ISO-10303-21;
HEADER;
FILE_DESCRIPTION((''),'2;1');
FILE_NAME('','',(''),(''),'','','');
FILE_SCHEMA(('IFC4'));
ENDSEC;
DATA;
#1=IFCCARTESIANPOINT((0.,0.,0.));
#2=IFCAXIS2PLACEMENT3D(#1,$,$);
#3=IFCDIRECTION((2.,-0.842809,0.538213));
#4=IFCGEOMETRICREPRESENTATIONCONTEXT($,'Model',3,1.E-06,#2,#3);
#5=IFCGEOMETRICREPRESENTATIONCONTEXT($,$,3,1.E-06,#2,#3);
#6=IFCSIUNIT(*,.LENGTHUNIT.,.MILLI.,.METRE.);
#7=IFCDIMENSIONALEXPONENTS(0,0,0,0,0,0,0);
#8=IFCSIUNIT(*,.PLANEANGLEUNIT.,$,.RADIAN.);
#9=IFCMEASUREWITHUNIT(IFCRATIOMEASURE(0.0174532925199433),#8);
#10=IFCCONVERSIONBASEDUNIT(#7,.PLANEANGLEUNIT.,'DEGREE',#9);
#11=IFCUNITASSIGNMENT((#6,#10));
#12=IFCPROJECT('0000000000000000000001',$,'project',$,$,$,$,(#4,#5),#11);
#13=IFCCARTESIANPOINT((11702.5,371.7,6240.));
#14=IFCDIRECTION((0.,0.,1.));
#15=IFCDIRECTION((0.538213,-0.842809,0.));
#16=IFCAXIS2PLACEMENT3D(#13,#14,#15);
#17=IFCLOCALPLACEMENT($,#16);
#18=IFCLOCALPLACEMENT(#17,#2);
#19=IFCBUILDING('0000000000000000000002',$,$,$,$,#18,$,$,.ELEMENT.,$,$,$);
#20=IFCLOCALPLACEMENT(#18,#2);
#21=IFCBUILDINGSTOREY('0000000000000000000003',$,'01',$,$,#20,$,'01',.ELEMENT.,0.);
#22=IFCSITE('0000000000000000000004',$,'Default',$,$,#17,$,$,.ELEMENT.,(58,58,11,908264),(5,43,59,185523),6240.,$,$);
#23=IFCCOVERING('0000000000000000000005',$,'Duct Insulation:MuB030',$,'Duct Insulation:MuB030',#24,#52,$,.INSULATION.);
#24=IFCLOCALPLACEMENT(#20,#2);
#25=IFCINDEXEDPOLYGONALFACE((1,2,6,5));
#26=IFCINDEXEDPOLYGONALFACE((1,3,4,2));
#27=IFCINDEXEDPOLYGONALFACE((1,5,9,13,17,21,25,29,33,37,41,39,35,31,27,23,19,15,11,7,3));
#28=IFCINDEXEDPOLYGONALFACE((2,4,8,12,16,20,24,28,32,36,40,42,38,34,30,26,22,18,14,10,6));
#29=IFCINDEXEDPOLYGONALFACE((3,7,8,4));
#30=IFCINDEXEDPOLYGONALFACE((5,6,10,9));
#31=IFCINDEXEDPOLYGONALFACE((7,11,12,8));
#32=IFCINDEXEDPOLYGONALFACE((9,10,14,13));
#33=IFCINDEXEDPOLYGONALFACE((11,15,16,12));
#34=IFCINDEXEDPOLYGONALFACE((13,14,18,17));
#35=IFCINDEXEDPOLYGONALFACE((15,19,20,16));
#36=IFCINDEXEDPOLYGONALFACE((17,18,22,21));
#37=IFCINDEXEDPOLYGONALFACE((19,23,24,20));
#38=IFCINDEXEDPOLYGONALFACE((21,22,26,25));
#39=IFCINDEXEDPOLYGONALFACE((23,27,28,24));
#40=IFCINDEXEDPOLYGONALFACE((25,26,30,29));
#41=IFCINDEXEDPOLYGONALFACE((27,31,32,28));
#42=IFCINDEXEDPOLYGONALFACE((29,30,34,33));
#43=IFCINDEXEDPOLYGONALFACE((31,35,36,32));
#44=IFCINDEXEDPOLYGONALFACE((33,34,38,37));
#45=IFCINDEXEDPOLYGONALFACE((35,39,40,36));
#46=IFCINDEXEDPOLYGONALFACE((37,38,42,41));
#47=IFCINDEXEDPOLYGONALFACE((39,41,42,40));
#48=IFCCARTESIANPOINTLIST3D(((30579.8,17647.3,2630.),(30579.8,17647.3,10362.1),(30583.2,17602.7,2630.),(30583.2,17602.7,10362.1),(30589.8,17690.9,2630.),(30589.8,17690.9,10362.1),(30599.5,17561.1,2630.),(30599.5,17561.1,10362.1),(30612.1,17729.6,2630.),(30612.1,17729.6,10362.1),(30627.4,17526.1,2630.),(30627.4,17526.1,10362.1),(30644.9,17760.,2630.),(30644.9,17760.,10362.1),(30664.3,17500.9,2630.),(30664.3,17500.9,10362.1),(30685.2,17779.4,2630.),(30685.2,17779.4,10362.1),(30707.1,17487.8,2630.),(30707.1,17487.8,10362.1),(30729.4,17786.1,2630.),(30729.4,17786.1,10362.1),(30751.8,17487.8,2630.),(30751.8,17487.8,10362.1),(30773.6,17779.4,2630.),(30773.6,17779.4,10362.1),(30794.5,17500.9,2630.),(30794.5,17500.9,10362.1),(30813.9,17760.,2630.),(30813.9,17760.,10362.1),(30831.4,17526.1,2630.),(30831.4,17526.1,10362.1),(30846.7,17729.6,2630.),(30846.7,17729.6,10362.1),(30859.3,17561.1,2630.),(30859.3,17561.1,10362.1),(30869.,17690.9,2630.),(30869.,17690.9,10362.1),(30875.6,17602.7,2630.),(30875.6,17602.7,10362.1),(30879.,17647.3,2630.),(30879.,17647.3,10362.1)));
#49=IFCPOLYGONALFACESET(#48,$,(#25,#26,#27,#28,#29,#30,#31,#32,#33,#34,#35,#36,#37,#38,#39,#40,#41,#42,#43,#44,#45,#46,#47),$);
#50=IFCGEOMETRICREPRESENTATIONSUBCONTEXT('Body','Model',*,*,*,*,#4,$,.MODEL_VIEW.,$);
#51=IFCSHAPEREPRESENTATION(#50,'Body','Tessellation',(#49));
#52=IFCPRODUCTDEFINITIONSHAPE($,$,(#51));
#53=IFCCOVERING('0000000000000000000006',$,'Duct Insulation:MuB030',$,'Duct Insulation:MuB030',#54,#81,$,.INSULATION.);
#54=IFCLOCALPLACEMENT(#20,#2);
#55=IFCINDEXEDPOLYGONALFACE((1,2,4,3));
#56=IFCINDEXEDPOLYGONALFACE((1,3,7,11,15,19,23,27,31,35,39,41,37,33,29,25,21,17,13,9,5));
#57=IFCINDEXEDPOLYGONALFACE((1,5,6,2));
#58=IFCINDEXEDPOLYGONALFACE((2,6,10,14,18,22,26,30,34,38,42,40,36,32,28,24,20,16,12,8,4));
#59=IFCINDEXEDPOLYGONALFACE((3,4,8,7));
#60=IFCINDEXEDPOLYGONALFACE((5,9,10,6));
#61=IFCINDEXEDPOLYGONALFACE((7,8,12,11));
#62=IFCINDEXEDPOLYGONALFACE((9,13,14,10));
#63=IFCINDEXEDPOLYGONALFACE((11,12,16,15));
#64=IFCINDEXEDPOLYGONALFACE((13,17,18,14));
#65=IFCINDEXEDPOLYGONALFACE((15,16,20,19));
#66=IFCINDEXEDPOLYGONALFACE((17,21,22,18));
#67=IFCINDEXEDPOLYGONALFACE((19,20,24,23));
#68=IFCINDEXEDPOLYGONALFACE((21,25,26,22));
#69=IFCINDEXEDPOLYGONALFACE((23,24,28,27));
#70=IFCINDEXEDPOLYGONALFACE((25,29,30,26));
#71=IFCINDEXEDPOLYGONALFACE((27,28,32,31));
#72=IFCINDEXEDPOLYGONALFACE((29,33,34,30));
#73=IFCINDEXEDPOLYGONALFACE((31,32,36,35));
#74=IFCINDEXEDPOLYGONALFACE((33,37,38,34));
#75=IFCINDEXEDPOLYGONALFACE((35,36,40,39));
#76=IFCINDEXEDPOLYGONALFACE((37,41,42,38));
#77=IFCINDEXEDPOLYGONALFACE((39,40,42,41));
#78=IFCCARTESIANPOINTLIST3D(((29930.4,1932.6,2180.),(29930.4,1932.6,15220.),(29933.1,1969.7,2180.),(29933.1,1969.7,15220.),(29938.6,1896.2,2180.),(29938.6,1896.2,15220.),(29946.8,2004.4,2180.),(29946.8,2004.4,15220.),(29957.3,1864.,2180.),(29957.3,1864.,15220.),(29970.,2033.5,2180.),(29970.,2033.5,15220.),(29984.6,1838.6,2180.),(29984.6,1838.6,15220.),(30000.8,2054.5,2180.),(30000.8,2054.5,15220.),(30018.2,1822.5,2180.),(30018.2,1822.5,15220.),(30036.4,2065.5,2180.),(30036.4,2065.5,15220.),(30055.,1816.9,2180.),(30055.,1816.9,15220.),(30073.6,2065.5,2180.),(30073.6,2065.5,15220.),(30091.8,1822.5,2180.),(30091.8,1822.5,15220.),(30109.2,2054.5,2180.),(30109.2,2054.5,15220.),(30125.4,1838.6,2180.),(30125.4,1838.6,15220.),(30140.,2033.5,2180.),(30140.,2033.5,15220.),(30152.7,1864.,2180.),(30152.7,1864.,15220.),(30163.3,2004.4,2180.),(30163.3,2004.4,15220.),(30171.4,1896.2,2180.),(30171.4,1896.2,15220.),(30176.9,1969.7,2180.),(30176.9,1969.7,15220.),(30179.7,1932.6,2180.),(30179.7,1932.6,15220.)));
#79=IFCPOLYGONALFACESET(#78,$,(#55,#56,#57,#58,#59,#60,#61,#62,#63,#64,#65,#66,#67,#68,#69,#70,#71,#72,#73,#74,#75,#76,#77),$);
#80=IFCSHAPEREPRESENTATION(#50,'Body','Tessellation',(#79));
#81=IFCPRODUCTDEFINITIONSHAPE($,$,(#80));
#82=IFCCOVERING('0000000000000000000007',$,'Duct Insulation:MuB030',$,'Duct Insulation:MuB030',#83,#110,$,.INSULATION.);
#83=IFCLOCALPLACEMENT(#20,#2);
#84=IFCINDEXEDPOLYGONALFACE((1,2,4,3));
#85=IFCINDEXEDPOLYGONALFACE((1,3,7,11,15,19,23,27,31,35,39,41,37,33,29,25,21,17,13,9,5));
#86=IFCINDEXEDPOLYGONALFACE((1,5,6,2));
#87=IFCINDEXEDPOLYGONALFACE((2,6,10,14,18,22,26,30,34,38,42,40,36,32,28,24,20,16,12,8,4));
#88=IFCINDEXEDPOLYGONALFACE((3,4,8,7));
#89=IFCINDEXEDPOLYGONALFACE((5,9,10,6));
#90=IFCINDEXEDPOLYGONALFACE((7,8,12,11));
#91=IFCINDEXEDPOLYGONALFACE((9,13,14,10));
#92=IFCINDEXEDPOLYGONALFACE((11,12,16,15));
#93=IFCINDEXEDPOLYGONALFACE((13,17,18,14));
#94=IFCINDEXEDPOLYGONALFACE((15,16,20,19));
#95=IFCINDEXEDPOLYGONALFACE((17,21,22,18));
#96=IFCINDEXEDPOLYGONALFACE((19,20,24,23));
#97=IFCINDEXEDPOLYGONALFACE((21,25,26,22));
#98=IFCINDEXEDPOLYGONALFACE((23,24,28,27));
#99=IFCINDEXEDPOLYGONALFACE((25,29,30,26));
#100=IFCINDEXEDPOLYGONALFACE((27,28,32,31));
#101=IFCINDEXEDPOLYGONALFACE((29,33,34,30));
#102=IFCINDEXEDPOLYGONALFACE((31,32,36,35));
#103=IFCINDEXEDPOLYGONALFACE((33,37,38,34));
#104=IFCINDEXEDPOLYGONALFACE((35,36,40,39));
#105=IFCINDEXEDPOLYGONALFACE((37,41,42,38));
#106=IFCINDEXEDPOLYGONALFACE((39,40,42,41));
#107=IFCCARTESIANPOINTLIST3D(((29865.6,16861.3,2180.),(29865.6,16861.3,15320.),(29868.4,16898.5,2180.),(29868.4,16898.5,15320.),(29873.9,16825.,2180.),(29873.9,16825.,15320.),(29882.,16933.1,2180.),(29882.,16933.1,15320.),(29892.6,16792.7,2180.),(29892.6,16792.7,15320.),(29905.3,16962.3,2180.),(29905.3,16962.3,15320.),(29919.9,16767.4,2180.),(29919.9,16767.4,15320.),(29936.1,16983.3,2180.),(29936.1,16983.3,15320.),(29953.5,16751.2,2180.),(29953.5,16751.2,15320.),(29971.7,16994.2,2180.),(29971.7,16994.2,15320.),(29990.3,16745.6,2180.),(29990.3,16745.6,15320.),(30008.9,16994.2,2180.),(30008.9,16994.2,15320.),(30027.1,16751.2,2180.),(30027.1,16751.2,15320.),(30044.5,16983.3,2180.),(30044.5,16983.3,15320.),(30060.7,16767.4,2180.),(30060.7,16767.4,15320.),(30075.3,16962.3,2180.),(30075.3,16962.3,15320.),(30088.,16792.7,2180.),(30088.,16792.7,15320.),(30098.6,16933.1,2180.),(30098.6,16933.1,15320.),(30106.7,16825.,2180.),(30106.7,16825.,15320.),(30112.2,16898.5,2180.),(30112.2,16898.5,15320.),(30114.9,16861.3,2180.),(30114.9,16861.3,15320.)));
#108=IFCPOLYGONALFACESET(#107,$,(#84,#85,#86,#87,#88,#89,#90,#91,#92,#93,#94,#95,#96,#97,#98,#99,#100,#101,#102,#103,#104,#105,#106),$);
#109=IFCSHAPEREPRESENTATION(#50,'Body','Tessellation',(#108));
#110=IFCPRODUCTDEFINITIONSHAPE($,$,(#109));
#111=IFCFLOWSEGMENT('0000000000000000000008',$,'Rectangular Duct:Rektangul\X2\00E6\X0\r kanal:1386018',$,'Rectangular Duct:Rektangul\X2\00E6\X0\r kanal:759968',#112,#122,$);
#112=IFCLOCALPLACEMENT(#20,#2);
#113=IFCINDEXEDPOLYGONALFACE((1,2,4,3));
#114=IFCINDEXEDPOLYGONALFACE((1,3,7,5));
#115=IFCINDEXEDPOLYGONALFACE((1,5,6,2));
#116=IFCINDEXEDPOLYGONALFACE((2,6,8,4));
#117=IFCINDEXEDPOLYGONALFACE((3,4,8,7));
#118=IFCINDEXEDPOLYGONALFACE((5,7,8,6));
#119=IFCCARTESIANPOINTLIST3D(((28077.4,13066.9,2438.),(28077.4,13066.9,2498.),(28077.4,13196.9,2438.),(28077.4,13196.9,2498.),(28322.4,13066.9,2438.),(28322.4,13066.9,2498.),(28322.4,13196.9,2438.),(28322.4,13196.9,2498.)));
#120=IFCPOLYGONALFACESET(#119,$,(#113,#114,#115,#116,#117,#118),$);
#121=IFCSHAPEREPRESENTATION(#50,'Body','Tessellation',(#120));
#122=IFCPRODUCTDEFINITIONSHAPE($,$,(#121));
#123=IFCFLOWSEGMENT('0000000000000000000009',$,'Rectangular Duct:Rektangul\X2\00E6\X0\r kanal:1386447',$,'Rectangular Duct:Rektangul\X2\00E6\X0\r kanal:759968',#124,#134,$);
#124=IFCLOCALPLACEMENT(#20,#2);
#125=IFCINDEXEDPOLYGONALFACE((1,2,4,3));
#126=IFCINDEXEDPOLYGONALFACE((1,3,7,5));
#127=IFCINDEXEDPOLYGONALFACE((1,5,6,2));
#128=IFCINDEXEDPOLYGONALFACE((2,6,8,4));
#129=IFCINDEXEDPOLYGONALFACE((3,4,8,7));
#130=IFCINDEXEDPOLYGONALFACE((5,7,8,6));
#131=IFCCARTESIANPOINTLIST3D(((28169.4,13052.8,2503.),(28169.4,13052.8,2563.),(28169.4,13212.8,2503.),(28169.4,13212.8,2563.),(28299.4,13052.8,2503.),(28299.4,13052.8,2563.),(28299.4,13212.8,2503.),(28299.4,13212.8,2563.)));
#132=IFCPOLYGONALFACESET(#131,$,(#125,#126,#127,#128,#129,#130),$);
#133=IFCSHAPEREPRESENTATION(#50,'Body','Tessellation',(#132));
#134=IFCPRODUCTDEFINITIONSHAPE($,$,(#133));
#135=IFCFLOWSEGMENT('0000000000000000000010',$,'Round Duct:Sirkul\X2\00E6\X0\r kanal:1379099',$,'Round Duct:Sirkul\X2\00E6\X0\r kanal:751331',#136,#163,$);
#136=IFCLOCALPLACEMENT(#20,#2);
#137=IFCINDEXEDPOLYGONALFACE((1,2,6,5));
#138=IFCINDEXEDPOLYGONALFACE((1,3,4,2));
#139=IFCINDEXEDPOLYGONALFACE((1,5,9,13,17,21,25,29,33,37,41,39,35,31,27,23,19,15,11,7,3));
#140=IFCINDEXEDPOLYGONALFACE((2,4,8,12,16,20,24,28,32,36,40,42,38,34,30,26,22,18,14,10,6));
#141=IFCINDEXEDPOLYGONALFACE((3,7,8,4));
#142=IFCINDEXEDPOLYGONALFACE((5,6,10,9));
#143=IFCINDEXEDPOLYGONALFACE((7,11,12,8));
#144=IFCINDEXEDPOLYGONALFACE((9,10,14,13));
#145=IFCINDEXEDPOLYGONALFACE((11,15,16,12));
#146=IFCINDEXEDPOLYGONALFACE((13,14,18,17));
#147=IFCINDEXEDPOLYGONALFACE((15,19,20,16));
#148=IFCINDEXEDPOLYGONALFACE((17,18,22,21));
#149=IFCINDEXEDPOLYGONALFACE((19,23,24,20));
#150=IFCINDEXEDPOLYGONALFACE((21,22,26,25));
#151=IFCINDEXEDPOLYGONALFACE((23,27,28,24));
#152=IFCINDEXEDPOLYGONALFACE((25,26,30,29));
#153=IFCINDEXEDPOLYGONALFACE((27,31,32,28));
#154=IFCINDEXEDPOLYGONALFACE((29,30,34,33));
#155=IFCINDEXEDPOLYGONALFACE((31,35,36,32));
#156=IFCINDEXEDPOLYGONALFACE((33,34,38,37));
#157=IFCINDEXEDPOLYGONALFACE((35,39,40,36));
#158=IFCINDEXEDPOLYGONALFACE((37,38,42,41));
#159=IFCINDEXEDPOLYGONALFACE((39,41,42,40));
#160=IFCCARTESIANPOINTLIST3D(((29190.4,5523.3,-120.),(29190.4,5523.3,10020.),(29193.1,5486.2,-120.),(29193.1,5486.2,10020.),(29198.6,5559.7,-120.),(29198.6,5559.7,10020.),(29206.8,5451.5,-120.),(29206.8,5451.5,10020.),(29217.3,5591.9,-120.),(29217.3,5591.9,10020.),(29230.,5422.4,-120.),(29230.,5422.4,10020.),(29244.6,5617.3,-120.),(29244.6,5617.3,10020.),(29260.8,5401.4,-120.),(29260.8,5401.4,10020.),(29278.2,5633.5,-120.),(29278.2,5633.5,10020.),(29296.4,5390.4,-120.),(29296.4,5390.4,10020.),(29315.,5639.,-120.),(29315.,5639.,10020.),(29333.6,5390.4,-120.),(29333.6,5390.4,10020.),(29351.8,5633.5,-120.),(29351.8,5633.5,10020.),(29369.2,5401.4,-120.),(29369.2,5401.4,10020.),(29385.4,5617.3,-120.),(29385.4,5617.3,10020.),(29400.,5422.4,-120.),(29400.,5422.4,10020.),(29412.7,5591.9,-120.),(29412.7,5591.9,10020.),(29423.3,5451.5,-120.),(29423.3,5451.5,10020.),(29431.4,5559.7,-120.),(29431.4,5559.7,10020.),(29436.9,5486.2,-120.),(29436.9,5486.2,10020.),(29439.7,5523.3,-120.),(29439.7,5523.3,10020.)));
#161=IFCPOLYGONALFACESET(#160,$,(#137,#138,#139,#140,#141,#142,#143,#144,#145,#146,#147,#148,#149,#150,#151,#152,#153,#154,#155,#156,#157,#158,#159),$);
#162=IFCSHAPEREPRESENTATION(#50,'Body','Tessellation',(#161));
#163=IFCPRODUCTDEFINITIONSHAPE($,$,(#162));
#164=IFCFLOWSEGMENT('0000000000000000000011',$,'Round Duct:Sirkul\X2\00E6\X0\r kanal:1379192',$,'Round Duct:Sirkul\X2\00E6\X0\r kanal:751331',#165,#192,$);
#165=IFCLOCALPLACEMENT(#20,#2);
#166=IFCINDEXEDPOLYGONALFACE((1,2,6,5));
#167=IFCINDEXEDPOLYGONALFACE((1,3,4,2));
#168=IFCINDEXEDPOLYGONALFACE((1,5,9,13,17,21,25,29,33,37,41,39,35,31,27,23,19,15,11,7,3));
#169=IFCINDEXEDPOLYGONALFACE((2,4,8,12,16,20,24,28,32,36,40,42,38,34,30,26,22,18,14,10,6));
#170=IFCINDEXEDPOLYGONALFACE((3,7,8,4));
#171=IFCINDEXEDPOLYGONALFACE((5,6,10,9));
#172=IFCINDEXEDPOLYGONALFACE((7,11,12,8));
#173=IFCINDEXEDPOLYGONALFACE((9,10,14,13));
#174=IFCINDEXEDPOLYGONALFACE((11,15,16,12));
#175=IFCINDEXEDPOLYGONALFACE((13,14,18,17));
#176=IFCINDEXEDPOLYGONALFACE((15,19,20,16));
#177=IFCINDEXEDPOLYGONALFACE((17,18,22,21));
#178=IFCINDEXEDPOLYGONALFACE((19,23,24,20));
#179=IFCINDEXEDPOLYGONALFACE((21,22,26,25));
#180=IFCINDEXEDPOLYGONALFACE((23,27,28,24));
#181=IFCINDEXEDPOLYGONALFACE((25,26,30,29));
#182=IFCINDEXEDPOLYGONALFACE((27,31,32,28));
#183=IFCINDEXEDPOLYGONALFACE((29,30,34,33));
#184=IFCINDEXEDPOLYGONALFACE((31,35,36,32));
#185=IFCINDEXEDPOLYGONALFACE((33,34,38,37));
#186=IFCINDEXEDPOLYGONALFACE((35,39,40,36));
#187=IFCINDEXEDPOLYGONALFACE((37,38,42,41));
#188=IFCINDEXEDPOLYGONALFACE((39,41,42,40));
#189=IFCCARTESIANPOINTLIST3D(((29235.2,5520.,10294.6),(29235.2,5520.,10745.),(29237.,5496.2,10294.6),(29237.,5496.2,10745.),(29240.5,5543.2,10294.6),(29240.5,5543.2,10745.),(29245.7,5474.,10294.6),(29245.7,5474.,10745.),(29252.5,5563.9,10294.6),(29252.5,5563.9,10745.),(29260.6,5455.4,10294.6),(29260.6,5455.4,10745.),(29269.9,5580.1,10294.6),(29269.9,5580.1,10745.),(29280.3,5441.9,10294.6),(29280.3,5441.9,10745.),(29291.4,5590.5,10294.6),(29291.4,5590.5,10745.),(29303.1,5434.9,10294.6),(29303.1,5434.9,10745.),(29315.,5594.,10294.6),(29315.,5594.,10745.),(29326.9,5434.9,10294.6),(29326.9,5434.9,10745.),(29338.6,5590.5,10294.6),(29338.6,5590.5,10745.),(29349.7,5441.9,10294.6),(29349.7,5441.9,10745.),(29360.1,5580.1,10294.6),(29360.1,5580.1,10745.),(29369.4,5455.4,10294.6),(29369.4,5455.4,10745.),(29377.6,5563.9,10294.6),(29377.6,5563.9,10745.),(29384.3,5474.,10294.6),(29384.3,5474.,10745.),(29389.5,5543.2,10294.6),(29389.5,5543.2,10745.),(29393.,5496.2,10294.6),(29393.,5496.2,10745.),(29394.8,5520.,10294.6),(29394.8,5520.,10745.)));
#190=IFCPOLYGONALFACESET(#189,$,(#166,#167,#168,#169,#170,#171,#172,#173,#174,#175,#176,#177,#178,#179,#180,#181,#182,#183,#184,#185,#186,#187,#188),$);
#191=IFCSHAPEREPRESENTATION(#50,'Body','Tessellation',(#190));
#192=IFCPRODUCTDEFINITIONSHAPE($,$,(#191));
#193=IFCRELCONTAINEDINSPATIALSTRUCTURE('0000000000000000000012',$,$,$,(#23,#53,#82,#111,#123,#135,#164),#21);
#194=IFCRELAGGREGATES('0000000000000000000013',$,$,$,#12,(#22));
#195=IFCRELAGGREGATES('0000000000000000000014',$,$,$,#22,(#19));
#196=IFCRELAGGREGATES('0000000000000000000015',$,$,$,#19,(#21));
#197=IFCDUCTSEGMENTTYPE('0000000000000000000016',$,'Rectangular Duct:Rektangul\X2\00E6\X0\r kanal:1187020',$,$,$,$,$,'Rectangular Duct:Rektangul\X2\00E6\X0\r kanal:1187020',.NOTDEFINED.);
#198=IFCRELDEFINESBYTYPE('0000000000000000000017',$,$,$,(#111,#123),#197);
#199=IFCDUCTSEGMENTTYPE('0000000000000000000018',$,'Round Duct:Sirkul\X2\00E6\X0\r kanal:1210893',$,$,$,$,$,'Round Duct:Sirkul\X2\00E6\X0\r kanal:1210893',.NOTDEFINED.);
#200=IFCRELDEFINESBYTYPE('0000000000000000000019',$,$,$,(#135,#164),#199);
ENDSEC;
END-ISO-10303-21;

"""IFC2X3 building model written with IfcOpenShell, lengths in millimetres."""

from ifc_helpers import new_model, entity, si_unit, converted_unit, direction, frame, frame_2d, origin, origin_2d_with_axis, place, context, subcontext, project, spatial, rectangle, circle, extrude, type_object, element, save


model = new_model("IFC2X3")

# Units and contexts
model_context = context("Model", 3, precision=1e-06, world=origin(), true_north=direction((2.0, -0.842809, 0.538213)))
context_of_model = context(None, 3, precision=1e-06, world=origin(), true_north=direction((2.0, -0.842809, 0.538213)))
body_context = subcontext(model_context, "Body", "Model", "MODEL_VIEW")
ifc_project = project(units=[si_unit("LENGTHUNIT", "METRE", prefix="MILLI"), converted_unit("PLANEANGLEUNIT", "DEGREE", entity("IfcRatioMeasure", 0.0174532925199433), si_unit("PLANEANGLEUNIT", "RADIAN"), dimensions=[0, 0, 0, 0, 0, 0, 0])], contexts=[model_context, context_of_model])

# Site, building, storey
site_placement = place(None, frame((11702.5, 371.7, 6240.0), z_axis=(0.0, 0.0, 1.0), x_axis=(0.538213, -0.842809, 0.0)))
site = spatial("IfcSite", under=ifc_project, at=site_placement, Name="Default", CompositionType="ELEMENT", RefLatitude=(58, 58, 11, 908264), RefLongitude=(5, 43, 59, 185523), RefElevation=6240.0)
building_placement = place(site_placement, origin())
building = spatial("IfcBuilding", under=site, at=building_placement, CompositionType="ELEMENT")
storey_placement = place(building_placement, origin())
storey = spatial("IfcBuildingStorey", under=building, at=storey_placement, Name="01", LongName="01", CompositionType="ELEMENT", Elevation=0.0)

# Coverings
covering_1_placement = place(storey_placement, origin())
element("IfcCovering", 1, at=covering_1_placement, inside=storey, Name="Duct Insulation:MuB030", ObjectType="Duct Insulation:MuB030", PredefinedType="INSULATION", context=body_context, shape_type="SweptSolid", body=[
    extrude(circle(Radius=150.0, at=frame_2d((0.0, 0.0), x_axis=(1.0, 0.0))), frame((30729.4, 17636.1, 2630.0), z_axis=(0.0, 0.0, 1.0), x_axis=(0.0, 1.0, 0.0)), (0.0, 0.0, 1.0), 7732.1),
])
covering_2_placement = place(storey_placement, origin())
element("IfcCovering", 2, at=covering_2_placement, inside=storey, Name="Duct Insulation:MuB030", ObjectType="Duct Insulation:MuB030", PredefinedType="INSULATION", context=body_context, shape_type="SweptSolid", body=[
    extrude(circle(Radius=125.0, at=frame_2d((0.0, 0.0), x_axis=(1.0, 0.0))), frame((30055.0, 1941.9, 2180.0), z_axis=(0.0, 0.0, 1.0), x_axis=(0.0, -1.0, 0.0)), (0.0, 0.0, 1.0), 13040.0),
])
covering_3_placement = place(storey_placement, origin())
element("IfcCovering", 3, at=covering_3_placement, inside=storey, Name="Duct Insulation:MuB030", ObjectType="Duct Insulation:MuB030", PredefinedType="INSULATION", context=body_context, shape_type="SweptSolid", body=[
    extrude(circle(Radius=125.0, at=origin_2d_with_axis()), frame((29990.3, 16870.6, 2180.0), z_axis=(0.0, 0.0, 1.0), x_axis=(0.0, -1.0, 0.0)), (0.0, 0.0, 1.0), 13140.0),
])

# Flow segments
duct_segment_type_1 = type_object("IfcDuctSegmentType", Name="Rectangular Duct:Rektangulær kanal:1187020", ElementType="Rectangular Duct:Rektangulær kanal:1187020", PredefinedType="NOTDEFINED")
flow_segment_1_placement = place(storey_placement, origin())
element("IfcFlowSegment", 4, at=flow_segment_1_placement, inside=storey, type_object=duct_segment_type_1, Name="Rectangular Duct:Rektangulær kanal:1386018", ObjectType="Rectangular Duct:Rektangulær kanal:759968", context=body_context, shape_type="SweptSolid", body=[
    extrude(rectangle(XDim=245.0, YDim=130.0, at=frame_2d((0.0, 0.0), x_axis=(1.0, 0.0))), frame((28199.9, 13131.9, 2438.0), z_axis=(0.0, 0.0, 1.0), x_axis=(-1.0, 0.0, 0.0)), (0.0, 0.0, 1.0), 60.0),
])
flow_segment_2_placement = place(storey_placement, origin())
element("IfcFlowSegment", 5, at=flow_segment_2_placement, inside=storey, type_object=duct_segment_type_1, Name="Rectangular Duct:Rektangulær kanal:1386447", ObjectType="Rectangular Duct:Rektangulær kanal:759968", context=body_context, shape_type="SweptSolid", body=[
    extrude(rectangle(XDim=160.0, YDim=130.0, at=frame_2d((0.0, 0.0), x_axis=(1.0, 0.0))), frame((28234.4, 13132.8, 2503.0), z_axis=(0.0, 0.0, 1.0), x_axis=(0.0, 1.0, 0.0)), (0.0, 0.0, 1.0), 60.0),
])
duct_segment_type_2 = type_object("IfcDuctSegmentType", Name="Round Duct:Sirkulær kanal:1210893", ElementType="Round Duct:Sirkulær kanal:1210893", PredefinedType="NOTDEFINED")
flow_segment_3_placement = place(storey_placement, origin())
element("IfcFlowSegment", 6, at=flow_segment_3_placement, inside=storey, type_object=duct_segment_type_2, Name="Round Duct:Sirkulær kanal:1379099", ObjectType="Round Duct:Sirkulær kanal:751331", context=body_context, shape_type="SweptSolid", body=[
    extrude(circle(Radius=125.0, at=frame_2d((0.0, 0.0), x_axis=(1.0, 0.0))), frame((29315.0, 5514.0, -120.0), z_axis=(0.0, 0.0, 1.0), x_axis=(0.0, 1.0, 0.0)), (0.0, 0.0, 1.0), 10140.0),
])
flow_segment_4_placement = place(storey_placement, origin())
element("IfcFlowSegment", 7, at=flow_segment_4_placement, inside=storey, type_object=duct_segment_type_2, Name="Round Duct:Sirkulær kanal:1379192", ObjectType="Round Duct:Sirkulær kanal:751331", context=body_context, shape_type="SweptSolid", body=[
    extrude(circle(Radius=80.0, at=origin_2d_with_axis()), frame((29315.0, 5514.0, 10294.6), z_axis=(0.0, 0.0, 1.0), x_axis=(0.0, 1.0, 0.0)), (0.0, 0.0, 1.0), 450.4),
])

save(model, "model.ifc")
